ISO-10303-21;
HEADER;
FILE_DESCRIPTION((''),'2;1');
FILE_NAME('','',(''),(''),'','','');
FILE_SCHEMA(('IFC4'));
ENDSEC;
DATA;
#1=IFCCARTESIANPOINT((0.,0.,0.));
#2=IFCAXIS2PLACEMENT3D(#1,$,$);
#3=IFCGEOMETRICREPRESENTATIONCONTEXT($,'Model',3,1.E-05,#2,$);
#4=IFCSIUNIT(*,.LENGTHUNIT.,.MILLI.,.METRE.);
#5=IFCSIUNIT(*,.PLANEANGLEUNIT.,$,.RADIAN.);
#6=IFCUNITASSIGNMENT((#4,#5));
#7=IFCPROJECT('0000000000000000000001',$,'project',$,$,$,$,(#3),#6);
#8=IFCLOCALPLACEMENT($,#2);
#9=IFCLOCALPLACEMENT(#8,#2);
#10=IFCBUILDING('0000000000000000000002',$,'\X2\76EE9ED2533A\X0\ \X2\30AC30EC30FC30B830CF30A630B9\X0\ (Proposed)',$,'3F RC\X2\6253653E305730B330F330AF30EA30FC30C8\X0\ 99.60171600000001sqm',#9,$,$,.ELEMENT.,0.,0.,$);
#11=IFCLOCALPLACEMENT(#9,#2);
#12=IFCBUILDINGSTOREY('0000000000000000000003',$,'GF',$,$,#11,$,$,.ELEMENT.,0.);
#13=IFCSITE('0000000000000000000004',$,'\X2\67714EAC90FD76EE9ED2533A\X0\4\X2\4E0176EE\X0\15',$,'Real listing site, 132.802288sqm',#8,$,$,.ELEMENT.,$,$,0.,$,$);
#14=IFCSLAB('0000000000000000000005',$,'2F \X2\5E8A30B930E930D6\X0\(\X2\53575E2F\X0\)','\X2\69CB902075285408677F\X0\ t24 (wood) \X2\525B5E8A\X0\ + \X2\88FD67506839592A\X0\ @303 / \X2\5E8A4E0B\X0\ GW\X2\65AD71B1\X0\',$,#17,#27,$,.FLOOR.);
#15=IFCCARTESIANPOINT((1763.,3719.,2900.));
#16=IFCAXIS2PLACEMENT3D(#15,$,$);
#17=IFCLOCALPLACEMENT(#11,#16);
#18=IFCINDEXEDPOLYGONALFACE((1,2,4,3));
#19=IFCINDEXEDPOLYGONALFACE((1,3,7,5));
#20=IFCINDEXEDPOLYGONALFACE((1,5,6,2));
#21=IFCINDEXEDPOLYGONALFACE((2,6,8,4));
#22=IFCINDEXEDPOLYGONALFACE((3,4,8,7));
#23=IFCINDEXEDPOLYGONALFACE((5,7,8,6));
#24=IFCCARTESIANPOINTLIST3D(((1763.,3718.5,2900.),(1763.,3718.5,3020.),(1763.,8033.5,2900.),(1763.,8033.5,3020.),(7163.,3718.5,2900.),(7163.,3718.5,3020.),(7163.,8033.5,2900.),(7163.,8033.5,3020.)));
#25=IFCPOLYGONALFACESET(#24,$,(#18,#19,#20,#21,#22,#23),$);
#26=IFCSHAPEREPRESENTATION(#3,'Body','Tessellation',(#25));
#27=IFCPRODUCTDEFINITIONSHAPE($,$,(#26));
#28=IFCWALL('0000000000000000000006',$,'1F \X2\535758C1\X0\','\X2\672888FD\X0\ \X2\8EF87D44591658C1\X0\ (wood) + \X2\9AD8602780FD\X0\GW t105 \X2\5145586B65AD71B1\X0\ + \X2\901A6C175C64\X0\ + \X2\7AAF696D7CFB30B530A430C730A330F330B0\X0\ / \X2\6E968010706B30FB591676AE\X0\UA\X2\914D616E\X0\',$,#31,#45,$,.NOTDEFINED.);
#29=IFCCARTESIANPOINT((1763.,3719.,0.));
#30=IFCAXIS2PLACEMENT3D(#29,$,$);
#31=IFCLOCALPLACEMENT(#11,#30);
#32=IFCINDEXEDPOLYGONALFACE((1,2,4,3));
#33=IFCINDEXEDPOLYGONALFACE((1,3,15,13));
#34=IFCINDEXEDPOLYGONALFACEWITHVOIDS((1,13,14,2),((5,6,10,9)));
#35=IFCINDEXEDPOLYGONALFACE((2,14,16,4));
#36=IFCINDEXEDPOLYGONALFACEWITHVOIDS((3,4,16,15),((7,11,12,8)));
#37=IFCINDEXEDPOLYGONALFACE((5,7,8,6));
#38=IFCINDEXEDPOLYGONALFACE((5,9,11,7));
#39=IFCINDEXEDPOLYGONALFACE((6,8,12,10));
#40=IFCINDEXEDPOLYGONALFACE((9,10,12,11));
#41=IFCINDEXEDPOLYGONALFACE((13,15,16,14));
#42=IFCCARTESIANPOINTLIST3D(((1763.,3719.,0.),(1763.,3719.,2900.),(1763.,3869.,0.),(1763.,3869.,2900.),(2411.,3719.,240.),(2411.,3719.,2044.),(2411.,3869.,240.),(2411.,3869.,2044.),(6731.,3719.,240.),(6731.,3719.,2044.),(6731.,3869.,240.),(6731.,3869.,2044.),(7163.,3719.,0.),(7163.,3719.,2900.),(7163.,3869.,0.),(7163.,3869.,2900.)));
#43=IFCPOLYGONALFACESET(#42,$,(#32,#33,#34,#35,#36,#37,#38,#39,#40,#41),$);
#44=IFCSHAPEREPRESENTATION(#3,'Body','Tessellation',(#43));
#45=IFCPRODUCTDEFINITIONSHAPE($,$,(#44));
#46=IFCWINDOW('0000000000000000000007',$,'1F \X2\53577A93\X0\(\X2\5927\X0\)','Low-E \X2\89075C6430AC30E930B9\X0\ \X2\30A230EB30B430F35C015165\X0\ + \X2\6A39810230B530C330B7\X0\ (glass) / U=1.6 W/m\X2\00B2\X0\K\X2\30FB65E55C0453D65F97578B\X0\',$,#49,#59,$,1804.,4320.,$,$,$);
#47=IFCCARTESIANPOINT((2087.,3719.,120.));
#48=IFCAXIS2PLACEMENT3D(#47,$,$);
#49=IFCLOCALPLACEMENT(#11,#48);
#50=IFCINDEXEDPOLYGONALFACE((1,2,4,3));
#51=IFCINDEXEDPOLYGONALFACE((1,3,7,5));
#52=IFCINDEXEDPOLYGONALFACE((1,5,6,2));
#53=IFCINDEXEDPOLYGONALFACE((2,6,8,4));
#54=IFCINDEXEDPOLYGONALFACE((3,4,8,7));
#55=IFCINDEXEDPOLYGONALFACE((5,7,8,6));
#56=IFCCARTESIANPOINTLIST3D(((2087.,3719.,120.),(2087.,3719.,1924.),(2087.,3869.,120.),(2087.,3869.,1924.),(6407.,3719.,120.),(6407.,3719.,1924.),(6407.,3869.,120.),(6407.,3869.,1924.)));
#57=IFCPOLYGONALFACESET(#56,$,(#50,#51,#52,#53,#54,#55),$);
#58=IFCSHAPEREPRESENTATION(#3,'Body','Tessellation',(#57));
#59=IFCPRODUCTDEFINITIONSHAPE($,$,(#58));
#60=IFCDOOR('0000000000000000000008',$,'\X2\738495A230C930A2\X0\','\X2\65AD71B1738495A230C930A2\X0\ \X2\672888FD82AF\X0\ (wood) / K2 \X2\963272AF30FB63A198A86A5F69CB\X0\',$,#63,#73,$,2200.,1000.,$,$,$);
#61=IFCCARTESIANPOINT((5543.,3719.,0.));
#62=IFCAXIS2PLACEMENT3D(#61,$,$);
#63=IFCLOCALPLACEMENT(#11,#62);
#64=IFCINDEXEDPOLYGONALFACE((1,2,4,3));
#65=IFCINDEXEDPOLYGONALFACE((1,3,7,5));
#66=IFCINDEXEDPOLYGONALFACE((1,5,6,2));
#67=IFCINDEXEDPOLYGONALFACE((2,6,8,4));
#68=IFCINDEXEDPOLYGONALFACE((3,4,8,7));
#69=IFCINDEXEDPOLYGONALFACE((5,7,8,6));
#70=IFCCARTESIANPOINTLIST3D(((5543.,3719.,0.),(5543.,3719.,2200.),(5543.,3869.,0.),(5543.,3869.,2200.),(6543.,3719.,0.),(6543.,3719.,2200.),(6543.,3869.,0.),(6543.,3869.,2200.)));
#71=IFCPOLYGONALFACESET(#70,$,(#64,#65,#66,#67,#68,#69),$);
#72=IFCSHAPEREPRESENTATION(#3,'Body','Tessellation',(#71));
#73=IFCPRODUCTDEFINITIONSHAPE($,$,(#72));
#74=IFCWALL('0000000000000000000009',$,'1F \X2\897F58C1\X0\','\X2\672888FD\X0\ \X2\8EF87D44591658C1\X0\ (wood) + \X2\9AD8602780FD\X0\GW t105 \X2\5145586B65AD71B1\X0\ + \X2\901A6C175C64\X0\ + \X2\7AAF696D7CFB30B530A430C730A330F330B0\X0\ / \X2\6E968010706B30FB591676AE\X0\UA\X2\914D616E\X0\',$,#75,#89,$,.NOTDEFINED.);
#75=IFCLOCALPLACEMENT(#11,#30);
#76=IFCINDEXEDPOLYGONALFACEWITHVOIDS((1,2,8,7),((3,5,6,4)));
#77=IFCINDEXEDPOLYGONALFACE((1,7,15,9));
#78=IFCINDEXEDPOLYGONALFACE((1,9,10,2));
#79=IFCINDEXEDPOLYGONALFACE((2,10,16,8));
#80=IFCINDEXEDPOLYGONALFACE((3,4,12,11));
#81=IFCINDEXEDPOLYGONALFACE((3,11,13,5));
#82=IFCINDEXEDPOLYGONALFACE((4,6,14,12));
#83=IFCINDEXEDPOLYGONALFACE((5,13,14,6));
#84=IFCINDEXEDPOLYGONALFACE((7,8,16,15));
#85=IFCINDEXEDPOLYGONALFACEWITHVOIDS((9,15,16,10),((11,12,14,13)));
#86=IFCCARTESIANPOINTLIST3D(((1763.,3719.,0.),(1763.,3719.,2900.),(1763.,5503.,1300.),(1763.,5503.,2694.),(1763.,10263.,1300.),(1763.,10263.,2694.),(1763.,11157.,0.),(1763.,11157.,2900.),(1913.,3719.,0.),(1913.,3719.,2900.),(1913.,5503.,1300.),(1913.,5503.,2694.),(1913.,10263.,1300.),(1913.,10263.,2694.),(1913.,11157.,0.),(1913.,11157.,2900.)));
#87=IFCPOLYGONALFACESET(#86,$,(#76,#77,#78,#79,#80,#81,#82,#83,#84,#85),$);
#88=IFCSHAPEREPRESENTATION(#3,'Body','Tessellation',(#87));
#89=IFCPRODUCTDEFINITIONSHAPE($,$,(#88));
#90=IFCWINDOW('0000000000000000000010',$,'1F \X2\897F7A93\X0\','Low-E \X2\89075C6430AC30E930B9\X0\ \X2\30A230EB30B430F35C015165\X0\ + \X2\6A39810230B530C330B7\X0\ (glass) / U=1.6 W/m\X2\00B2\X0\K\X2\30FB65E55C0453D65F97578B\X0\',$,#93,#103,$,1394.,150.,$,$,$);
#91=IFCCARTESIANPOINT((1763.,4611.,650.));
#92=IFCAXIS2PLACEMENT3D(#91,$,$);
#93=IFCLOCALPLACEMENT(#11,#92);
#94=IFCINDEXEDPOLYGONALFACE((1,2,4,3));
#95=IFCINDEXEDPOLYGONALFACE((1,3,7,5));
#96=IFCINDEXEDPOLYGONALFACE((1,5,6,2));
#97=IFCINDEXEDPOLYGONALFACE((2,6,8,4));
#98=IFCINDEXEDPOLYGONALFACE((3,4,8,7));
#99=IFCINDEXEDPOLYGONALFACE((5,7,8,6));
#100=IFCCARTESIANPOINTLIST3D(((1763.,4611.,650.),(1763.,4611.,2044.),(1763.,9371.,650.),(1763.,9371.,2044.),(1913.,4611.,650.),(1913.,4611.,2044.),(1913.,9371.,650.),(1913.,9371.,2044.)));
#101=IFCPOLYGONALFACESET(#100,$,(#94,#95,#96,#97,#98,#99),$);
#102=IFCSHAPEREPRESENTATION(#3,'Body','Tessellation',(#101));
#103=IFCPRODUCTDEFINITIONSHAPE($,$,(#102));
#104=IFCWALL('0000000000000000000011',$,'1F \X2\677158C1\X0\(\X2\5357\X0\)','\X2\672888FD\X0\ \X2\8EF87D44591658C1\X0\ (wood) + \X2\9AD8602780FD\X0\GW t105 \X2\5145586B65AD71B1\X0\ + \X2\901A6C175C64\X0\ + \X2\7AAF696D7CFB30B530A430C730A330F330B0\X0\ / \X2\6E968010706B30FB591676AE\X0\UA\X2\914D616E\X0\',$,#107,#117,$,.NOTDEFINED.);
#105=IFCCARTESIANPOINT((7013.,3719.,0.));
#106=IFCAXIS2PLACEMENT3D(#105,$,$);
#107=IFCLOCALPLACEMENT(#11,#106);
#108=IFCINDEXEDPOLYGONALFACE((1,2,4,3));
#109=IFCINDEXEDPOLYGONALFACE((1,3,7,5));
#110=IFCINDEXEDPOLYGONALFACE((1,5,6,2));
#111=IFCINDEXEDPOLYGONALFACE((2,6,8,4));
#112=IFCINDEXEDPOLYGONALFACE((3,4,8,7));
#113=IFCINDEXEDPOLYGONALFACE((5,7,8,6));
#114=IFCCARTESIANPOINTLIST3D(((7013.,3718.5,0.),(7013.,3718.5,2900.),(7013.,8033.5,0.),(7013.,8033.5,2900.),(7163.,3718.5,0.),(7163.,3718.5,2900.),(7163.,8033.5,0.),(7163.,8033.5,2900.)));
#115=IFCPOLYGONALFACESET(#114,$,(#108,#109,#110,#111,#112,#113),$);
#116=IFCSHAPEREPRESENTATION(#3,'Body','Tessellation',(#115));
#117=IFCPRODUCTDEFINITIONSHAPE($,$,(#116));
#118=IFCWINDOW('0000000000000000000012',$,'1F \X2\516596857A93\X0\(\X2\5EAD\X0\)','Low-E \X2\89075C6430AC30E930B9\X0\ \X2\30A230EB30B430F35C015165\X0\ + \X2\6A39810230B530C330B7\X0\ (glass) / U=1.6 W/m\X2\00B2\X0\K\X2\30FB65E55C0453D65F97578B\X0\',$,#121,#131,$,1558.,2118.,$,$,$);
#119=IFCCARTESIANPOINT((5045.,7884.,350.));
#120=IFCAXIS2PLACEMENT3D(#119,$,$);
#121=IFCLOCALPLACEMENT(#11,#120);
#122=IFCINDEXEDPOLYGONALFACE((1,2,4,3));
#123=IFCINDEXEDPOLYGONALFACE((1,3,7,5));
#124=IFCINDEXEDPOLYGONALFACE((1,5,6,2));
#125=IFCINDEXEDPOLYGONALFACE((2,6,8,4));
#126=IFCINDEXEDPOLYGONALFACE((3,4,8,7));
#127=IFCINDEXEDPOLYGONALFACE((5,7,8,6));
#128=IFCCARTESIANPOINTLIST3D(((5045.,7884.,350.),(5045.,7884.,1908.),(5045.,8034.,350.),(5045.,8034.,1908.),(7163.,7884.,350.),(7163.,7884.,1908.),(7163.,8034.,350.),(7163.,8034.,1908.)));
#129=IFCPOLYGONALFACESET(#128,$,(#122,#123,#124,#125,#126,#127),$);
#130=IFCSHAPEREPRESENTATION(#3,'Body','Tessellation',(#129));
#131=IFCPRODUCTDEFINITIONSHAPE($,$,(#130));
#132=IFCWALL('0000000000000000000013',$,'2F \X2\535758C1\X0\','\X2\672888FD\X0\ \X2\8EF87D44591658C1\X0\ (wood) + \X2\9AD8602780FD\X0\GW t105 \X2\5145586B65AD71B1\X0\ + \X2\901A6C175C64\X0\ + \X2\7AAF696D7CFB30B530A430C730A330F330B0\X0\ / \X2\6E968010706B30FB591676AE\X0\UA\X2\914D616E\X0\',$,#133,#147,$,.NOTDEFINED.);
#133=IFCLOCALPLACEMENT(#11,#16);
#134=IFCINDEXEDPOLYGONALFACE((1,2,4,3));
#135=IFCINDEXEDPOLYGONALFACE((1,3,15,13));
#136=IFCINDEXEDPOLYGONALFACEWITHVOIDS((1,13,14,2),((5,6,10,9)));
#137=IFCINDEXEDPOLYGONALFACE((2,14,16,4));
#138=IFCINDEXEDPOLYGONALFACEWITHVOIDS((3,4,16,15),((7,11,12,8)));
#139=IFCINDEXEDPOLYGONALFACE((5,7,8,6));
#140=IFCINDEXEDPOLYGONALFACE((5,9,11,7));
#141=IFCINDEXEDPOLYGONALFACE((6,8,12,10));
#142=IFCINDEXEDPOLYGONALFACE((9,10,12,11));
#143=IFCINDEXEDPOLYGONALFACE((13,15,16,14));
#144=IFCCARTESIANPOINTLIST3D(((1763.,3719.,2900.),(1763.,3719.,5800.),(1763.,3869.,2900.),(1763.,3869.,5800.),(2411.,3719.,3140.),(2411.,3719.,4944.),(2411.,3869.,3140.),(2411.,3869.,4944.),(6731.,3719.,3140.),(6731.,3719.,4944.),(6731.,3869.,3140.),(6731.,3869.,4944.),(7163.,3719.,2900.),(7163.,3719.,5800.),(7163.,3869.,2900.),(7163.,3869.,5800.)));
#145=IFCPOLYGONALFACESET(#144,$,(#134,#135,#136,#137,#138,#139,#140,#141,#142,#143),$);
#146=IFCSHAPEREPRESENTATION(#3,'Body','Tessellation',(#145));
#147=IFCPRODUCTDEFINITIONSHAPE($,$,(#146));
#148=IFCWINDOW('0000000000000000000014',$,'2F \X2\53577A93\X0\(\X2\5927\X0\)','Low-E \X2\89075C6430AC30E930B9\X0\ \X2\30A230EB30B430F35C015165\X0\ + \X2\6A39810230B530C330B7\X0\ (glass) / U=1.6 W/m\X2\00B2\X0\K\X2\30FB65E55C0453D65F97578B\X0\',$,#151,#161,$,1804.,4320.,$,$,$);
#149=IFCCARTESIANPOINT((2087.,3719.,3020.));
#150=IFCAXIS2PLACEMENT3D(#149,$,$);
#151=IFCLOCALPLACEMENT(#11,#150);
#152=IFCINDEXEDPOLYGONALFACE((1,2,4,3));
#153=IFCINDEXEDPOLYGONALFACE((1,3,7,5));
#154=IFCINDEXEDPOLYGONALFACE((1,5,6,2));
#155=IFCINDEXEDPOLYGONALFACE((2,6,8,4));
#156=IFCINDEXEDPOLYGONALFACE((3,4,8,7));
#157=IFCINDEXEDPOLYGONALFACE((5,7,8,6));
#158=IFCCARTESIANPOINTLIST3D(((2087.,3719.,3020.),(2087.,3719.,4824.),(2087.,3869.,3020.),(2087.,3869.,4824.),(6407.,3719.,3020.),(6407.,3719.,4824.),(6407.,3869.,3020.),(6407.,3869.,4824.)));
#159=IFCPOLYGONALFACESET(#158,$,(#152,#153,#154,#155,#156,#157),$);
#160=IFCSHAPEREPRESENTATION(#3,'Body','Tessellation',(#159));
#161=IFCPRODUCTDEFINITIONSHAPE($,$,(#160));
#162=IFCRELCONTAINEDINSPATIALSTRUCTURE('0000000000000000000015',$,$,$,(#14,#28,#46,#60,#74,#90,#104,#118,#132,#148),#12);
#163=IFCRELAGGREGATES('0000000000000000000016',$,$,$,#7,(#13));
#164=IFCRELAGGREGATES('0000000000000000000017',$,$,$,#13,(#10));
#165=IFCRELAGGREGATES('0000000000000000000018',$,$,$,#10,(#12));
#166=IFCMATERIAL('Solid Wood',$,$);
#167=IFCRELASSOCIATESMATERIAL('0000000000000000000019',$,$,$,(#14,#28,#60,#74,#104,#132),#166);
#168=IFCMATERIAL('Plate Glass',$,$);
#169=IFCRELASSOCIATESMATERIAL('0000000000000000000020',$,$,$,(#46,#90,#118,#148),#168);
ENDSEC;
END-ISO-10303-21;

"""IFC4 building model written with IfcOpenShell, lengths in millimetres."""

from ifc_helpers import new_model, si_unit, frame, frame_2d, origin, place, context, project, spatial, rectangle, extrude, material, element, fill, save


model = new_model("IFC4")

# Units and contexts
model_context = context("Model", 3, precision=1e-05, world=origin())
ifc_project = project(units=[si_unit("LENGTHUNIT", "METRE", prefix="MILLI"), si_unit("PLANEANGLEUNIT", "RADIAN")], contexts=[model_context])

# Site, building, storey
site_placement = place(None, origin())
site = spatial("IfcSite", under=ifc_project, at=site_placement, Name="東京都目黒区4丁目15", ObjectType="Real listing site, 132.802288sqm", CompositionType="ELEMENT", RefElevation=0.0)
building_placement = place(site_placement, origin())
building = spatial("IfcBuilding", under=site, at=building_placement, Name="目黒区 ガレージハウス (Proposed)", ObjectType="3F RC打放しコンクリート 99.60171600000001sqm", CompositionType="ELEMENT", ElevationOfRefHeight=0.0, ElevationOfTerrain=0.0)
storey_placement = place(building_placement, origin())
storey = spatial("IfcBuildingStorey", under=building, at=storey_placement, Name="GF", CompositionType="ELEMENT", Elevation=0.0)

# Slab
ifc_material_1 = material(Name="Solid Wood")
slab_1_placement = place(storey_placement, frame((1763.0, 3719.0, 2900.0)))
element("IfcSlab", 1, at=slab_1_placement, inside=storey, material=ifc_material_1, Name="2F 床スラブ(南帯)", Description="構造用合板 t24 (wood) 剛床 + 製材根太 @303 / 床下 GW断熱", PredefinedType="FLOOR", context=model_context, shape_type="SweptSolid", body=[
    extrude(rectangle(XDim=5400.0, YDim=4315.0, at=frame_2d((2700.0, 2157.0))), frame((1763.0, 3719.0, 2900.0)), (0.0, 0.0, 1.0), 120.0),
])

# Wall, openings, window, door
wall_1_placement = place(storey_placement, frame((1763.0, 3719.0, 0.0)))
wall_1 = element("IfcWall", 2, at=wall_1_placement, inside=storey, material=ifc_material_1, Name="1F 南壁", Description="木製 軸組外壁 (wood) + 高性能GW t105 充填断熱 + 通気層 + 窯業系サイディング / 準耐火・外皮UA配慮", PredefinedType="NOTDEFINED", context=model_context, shape_type="SweptSolid", body=[
    extrude(rectangle(XDim=5400.0, YDim=150.0, at=frame_2d((2700.0, 75.0))), frame((1763.0, 3719.0, 0.0)), (0.0, 0.0, 1.0), 2900.0),
])
opening_1_placement = place(storey_placement, frame((2087.0, 3719.0, 120.0)))
opening_1 = element("IfcOpeningElement", 3, at=opening_1_placement, cuts=wall_1, PredefinedType="NOTDEFINED", context=model_context, shape_type="SweptSolid", body=[
    extrude(rectangle(XDim=4320.0, YDim=150.0, at=frame_2d((2160.0, 75.0))), frame((2087.0, 3719.0, 120.0)), (0.0, 0.0, 1.0), 1804.0),
])
opening_2_placement = place(storey_placement, frame((5543.0, 3719.0, 0.0)))
opening_2 = element("IfcOpeningElement", 4, at=opening_2_placement, cuts=wall_1, PredefinedType="NOTDEFINED", context=model_context, shape_type="SweptSolid", body=[
    extrude(rectangle(XDim=1000.0, YDim=150.0, at=frame_2d((500.0, 75.0))), frame((5543.0, 3719.0, 0.0)), (0.0, 0.0, 1.0), 2200.0),
])
ifc_material_2 = material(Name="Plate Glass")
window_1_placement = place(storey_placement, frame((2087.0, 3719.0, 120.0)))
window_1 = element("IfcWindow", 5, at=window_1_placement, inside=storey, material=ifc_material_2, Name="1F 南窓(大)", Description="Low-E 複層ガラス アルゴン封入 + 樹脂サッシ (glass) / U=1.6 W/m²K・日射取得型", OverallHeight=1804.0, OverallWidth=4320.0, context=model_context, shape_type="SweptSolid", body=[
    extrude(rectangle(XDim=4320.0, YDim=150.0, at=frame_2d((2160.0, 75.0))), frame((2087.0, 3719.0, 120.0)), (0.0, 0.0, 1.0), 1804.0),
])
fill(opening_1, window_1)
door_1_placement = place(storey_placement, frame((5543.0, 3719.0, 0.0)))
door_1 = element("IfcDoor", 6, at=door_1_placement, inside=storey, material=ifc_material_1, Name="玄関ドア", Description="断熱玄関ドア 木製芯 (wood) / K2 防犯・採風機構", OverallHeight=2200.0, OverallWidth=1000.0, context=model_context, shape_type="SweptSolid", body=[
    extrude(rectangle(XDim=1000.0, YDim=150.0, at=frame_2d((500.0, 75.0))), frame((5543.0, 3719.0, 0.0)), (0.0, 0.0, 1.0), 2200.0),
])
fill(opening_2, door_1)

# Walls, openings, windows
wall_2_placement = place(storey_placement, frame((1763.0, 3719.0, 0.0)))
wall_2 = element("IfcWall", 7, at=wall_2_placement, inside=storey, material=ifc_material_1, Name="1F 西壁", Description="木製 軸組外壁 (wood) + 高性能GW t105 充填断熱 + 通気層 + 窯業系サイディング / 準耐火・外皮UA配慮", PredefinedType="NOTDEFINED", context=model_context, shape_type="SweptSolid", body=[
    extrude(rectangle(XDim=150.0, YDim=7438.0, at=frame_2d((75.0, 3719.0))), frame((1763.0, 3719.0, 0.0)), (0.0, 0.0, 1.0), 2900.0),
])
opening_3_placement = place(storey_placement, frame((1763.0, 4611.0, 650.0)))
opening_3 = element("IfcOpeningElement", 8, at=opening_3_placement, cuts=wall_2, PredefinedType="NOTDEFINED", context=model_context, shape_type="SweptSolid", body=[
    extrude(rectangle(XDim=150.0, YDim=4760.0, at=frame_2d((75.0, 2380.0))), frame((1763.0, 4611.0, 650.0)), (0.0, 0.0, 1.0), 1394.0),
])
window_2_placement = place(storey_placement, frame((1763.0, 4611.0, 650.0)))
window_2 = element("IfcWindow", 9, at=window_2_placement, inside=storey, material=ifc_material_2, Name="1F 西窓", Description="Low-E 複層ガラス アルゴン封入 + 樹脂サッシ (glass) / U=1.6 W/m²K・日射取得型", OverallHeight=1394.0, OverallWidth=150.0, context=model_context, shape_type="SweptSolid", body=[
    extrude(rectangle(XDim=150.0, YDim=4760.0, at=frame_2d((75.0, 2380.0))), frame((1763.0, 4611.0, 650.0)), (0.0, 0.0, 1.0), 1394.0),
])
fill(opening_3, window_2)
wall_3_placement = place(storey_placement, frame((7013.0, 3719.0, 0.0)))
wall_3 = element("IfcWall", 10, at=wall_3_placement, inside=storey, material=ifc_material_1, Name="1F 東壁(南)", Description="木製 軸組外壁 (wood) + 高性能GW t105 充填断熱 + 通気層 + 窯業系サイディング / 準耐火・外皮UA配慮", PredefinedType="NOTDEFINED", context=model_context, shape_type="SweptSolid", body=[
    extrude(rectangle(XDim=150.0, YDim=4315.0, at=frame_2d((75.0, 2157.0))), frame((7013.0, 3719.0, 0.0)), (0.0, 0.0, 1.0), 2900.0),
])
opening_4_placement = place(storey_placement, frame((5045.0, 7884.0, 350.0)))
opening_4 = element("IfcOpeningElement", 11, at=opening_4_placement, cuts=wall_3, PredefinedType="NOTDEFINED", context=model_context, shape_type="SweptSolid", body=[
    extrude(rectangle(XDim=2118.0, YDim=150.0, at=frame_2d((1059.0, 75.0))), frame((5045.0, 7884.0, 350.0)), (0.0, 0.0, 1.0), 1558.0),
])
window_3_placement = place(storey_placement, frame((5045.0, 7884.0, 350.0)))
window_3 = element("IfcWindow", 12, at=window_3_placement, inside=storey, material=ifc_material_2, Name="1F 入隅窓(庭)", Description="Low-E 複層ガラス アルゴン封入 + 樹脂サッシ (glass) / U=1.6 W/m²K・日射取得型", OverallHeight=1558.0, OverallWidth=2118.0, context=model_context, shape_type="SweptSolid", body=[
    extrude(rectangle(XDim=2118.0, YDim=150.0, at=frame_2d((1059.0, 75.0))), frame((5045.0, 7884.0, 350.0)), (0.0, 0.0, 1.0), 1558.0),
])
fill(opening_4, window_3)

# Wall, opening, window
wall_4_placement = place(storey_placement, frame((1763.0, 3719.0, 2900.0)))
wall_4 = element("IfcWall", 13, at=wall_4_placement, inside=storey, material=ifc_material_1, Name="2F 南壁", Description="木製 軸組外壁 (wood) + 高性能GW t105 充填断熱 + 通気層 + 窯業系サイディング / 準耐火・外皮UA配慮", PredefinedType="NOTDEFINED", context=model_context, shape_type="SweptSolid", body=[
    extrude(rectangle(XDim=5400.0, YDim=150.0, at=frame_2d((2700.0, 75.0))), frame((1763.0, 3719.0, 2900.0)), (0.0, 0.0, 1.0), 2900.0),
])
opening_5_placement = place(storey_placement, frame((2087.0, 3719.0, 3020.0)))
opening_5 = element("IfcOpeningElement", 14, at=opening_5_placement, cuts=wall_4, PredefinedType="NOTDEFINED", context=model_context, shape_type="SweptSolid", body=[
    extrude(rectangle(XDim=4320.0, YDim=150.0, at=frame_2d((2160.0, 75.0))), frame((2087.0, 3719.0, 3020.0)), (0.0, 0.0, 1.0), 1804.0),
])
window_4_placement = place(storey_placement, frame((2087.0, 3719.0, 3020.0)))
window_4 = element("IfcWindow", 15, at=window_4_placement, inside=storey, material=ifc_material_2, Name="2F 南窓(大)", Description="Low-E 複層ガラス アルゴン封入 + 樹脂サッシ (glass) / U=1.6 W/m²K・日射取得型", OverallHeight=1804.0, OverallWidth=4320.0, context=model_context, shape_type="SweptSolid", body=[
    extrude(rectangle(XDim=4320.0, YDim=150.0, at=frame_2d((2160.0, 75.0))), frame((2087.0, 3719.0, 3020.0)), (0.0, 0.0, 1.0), 1804.0),
])
fill(opening_5, window_4)

save(model, "model.ifc")
